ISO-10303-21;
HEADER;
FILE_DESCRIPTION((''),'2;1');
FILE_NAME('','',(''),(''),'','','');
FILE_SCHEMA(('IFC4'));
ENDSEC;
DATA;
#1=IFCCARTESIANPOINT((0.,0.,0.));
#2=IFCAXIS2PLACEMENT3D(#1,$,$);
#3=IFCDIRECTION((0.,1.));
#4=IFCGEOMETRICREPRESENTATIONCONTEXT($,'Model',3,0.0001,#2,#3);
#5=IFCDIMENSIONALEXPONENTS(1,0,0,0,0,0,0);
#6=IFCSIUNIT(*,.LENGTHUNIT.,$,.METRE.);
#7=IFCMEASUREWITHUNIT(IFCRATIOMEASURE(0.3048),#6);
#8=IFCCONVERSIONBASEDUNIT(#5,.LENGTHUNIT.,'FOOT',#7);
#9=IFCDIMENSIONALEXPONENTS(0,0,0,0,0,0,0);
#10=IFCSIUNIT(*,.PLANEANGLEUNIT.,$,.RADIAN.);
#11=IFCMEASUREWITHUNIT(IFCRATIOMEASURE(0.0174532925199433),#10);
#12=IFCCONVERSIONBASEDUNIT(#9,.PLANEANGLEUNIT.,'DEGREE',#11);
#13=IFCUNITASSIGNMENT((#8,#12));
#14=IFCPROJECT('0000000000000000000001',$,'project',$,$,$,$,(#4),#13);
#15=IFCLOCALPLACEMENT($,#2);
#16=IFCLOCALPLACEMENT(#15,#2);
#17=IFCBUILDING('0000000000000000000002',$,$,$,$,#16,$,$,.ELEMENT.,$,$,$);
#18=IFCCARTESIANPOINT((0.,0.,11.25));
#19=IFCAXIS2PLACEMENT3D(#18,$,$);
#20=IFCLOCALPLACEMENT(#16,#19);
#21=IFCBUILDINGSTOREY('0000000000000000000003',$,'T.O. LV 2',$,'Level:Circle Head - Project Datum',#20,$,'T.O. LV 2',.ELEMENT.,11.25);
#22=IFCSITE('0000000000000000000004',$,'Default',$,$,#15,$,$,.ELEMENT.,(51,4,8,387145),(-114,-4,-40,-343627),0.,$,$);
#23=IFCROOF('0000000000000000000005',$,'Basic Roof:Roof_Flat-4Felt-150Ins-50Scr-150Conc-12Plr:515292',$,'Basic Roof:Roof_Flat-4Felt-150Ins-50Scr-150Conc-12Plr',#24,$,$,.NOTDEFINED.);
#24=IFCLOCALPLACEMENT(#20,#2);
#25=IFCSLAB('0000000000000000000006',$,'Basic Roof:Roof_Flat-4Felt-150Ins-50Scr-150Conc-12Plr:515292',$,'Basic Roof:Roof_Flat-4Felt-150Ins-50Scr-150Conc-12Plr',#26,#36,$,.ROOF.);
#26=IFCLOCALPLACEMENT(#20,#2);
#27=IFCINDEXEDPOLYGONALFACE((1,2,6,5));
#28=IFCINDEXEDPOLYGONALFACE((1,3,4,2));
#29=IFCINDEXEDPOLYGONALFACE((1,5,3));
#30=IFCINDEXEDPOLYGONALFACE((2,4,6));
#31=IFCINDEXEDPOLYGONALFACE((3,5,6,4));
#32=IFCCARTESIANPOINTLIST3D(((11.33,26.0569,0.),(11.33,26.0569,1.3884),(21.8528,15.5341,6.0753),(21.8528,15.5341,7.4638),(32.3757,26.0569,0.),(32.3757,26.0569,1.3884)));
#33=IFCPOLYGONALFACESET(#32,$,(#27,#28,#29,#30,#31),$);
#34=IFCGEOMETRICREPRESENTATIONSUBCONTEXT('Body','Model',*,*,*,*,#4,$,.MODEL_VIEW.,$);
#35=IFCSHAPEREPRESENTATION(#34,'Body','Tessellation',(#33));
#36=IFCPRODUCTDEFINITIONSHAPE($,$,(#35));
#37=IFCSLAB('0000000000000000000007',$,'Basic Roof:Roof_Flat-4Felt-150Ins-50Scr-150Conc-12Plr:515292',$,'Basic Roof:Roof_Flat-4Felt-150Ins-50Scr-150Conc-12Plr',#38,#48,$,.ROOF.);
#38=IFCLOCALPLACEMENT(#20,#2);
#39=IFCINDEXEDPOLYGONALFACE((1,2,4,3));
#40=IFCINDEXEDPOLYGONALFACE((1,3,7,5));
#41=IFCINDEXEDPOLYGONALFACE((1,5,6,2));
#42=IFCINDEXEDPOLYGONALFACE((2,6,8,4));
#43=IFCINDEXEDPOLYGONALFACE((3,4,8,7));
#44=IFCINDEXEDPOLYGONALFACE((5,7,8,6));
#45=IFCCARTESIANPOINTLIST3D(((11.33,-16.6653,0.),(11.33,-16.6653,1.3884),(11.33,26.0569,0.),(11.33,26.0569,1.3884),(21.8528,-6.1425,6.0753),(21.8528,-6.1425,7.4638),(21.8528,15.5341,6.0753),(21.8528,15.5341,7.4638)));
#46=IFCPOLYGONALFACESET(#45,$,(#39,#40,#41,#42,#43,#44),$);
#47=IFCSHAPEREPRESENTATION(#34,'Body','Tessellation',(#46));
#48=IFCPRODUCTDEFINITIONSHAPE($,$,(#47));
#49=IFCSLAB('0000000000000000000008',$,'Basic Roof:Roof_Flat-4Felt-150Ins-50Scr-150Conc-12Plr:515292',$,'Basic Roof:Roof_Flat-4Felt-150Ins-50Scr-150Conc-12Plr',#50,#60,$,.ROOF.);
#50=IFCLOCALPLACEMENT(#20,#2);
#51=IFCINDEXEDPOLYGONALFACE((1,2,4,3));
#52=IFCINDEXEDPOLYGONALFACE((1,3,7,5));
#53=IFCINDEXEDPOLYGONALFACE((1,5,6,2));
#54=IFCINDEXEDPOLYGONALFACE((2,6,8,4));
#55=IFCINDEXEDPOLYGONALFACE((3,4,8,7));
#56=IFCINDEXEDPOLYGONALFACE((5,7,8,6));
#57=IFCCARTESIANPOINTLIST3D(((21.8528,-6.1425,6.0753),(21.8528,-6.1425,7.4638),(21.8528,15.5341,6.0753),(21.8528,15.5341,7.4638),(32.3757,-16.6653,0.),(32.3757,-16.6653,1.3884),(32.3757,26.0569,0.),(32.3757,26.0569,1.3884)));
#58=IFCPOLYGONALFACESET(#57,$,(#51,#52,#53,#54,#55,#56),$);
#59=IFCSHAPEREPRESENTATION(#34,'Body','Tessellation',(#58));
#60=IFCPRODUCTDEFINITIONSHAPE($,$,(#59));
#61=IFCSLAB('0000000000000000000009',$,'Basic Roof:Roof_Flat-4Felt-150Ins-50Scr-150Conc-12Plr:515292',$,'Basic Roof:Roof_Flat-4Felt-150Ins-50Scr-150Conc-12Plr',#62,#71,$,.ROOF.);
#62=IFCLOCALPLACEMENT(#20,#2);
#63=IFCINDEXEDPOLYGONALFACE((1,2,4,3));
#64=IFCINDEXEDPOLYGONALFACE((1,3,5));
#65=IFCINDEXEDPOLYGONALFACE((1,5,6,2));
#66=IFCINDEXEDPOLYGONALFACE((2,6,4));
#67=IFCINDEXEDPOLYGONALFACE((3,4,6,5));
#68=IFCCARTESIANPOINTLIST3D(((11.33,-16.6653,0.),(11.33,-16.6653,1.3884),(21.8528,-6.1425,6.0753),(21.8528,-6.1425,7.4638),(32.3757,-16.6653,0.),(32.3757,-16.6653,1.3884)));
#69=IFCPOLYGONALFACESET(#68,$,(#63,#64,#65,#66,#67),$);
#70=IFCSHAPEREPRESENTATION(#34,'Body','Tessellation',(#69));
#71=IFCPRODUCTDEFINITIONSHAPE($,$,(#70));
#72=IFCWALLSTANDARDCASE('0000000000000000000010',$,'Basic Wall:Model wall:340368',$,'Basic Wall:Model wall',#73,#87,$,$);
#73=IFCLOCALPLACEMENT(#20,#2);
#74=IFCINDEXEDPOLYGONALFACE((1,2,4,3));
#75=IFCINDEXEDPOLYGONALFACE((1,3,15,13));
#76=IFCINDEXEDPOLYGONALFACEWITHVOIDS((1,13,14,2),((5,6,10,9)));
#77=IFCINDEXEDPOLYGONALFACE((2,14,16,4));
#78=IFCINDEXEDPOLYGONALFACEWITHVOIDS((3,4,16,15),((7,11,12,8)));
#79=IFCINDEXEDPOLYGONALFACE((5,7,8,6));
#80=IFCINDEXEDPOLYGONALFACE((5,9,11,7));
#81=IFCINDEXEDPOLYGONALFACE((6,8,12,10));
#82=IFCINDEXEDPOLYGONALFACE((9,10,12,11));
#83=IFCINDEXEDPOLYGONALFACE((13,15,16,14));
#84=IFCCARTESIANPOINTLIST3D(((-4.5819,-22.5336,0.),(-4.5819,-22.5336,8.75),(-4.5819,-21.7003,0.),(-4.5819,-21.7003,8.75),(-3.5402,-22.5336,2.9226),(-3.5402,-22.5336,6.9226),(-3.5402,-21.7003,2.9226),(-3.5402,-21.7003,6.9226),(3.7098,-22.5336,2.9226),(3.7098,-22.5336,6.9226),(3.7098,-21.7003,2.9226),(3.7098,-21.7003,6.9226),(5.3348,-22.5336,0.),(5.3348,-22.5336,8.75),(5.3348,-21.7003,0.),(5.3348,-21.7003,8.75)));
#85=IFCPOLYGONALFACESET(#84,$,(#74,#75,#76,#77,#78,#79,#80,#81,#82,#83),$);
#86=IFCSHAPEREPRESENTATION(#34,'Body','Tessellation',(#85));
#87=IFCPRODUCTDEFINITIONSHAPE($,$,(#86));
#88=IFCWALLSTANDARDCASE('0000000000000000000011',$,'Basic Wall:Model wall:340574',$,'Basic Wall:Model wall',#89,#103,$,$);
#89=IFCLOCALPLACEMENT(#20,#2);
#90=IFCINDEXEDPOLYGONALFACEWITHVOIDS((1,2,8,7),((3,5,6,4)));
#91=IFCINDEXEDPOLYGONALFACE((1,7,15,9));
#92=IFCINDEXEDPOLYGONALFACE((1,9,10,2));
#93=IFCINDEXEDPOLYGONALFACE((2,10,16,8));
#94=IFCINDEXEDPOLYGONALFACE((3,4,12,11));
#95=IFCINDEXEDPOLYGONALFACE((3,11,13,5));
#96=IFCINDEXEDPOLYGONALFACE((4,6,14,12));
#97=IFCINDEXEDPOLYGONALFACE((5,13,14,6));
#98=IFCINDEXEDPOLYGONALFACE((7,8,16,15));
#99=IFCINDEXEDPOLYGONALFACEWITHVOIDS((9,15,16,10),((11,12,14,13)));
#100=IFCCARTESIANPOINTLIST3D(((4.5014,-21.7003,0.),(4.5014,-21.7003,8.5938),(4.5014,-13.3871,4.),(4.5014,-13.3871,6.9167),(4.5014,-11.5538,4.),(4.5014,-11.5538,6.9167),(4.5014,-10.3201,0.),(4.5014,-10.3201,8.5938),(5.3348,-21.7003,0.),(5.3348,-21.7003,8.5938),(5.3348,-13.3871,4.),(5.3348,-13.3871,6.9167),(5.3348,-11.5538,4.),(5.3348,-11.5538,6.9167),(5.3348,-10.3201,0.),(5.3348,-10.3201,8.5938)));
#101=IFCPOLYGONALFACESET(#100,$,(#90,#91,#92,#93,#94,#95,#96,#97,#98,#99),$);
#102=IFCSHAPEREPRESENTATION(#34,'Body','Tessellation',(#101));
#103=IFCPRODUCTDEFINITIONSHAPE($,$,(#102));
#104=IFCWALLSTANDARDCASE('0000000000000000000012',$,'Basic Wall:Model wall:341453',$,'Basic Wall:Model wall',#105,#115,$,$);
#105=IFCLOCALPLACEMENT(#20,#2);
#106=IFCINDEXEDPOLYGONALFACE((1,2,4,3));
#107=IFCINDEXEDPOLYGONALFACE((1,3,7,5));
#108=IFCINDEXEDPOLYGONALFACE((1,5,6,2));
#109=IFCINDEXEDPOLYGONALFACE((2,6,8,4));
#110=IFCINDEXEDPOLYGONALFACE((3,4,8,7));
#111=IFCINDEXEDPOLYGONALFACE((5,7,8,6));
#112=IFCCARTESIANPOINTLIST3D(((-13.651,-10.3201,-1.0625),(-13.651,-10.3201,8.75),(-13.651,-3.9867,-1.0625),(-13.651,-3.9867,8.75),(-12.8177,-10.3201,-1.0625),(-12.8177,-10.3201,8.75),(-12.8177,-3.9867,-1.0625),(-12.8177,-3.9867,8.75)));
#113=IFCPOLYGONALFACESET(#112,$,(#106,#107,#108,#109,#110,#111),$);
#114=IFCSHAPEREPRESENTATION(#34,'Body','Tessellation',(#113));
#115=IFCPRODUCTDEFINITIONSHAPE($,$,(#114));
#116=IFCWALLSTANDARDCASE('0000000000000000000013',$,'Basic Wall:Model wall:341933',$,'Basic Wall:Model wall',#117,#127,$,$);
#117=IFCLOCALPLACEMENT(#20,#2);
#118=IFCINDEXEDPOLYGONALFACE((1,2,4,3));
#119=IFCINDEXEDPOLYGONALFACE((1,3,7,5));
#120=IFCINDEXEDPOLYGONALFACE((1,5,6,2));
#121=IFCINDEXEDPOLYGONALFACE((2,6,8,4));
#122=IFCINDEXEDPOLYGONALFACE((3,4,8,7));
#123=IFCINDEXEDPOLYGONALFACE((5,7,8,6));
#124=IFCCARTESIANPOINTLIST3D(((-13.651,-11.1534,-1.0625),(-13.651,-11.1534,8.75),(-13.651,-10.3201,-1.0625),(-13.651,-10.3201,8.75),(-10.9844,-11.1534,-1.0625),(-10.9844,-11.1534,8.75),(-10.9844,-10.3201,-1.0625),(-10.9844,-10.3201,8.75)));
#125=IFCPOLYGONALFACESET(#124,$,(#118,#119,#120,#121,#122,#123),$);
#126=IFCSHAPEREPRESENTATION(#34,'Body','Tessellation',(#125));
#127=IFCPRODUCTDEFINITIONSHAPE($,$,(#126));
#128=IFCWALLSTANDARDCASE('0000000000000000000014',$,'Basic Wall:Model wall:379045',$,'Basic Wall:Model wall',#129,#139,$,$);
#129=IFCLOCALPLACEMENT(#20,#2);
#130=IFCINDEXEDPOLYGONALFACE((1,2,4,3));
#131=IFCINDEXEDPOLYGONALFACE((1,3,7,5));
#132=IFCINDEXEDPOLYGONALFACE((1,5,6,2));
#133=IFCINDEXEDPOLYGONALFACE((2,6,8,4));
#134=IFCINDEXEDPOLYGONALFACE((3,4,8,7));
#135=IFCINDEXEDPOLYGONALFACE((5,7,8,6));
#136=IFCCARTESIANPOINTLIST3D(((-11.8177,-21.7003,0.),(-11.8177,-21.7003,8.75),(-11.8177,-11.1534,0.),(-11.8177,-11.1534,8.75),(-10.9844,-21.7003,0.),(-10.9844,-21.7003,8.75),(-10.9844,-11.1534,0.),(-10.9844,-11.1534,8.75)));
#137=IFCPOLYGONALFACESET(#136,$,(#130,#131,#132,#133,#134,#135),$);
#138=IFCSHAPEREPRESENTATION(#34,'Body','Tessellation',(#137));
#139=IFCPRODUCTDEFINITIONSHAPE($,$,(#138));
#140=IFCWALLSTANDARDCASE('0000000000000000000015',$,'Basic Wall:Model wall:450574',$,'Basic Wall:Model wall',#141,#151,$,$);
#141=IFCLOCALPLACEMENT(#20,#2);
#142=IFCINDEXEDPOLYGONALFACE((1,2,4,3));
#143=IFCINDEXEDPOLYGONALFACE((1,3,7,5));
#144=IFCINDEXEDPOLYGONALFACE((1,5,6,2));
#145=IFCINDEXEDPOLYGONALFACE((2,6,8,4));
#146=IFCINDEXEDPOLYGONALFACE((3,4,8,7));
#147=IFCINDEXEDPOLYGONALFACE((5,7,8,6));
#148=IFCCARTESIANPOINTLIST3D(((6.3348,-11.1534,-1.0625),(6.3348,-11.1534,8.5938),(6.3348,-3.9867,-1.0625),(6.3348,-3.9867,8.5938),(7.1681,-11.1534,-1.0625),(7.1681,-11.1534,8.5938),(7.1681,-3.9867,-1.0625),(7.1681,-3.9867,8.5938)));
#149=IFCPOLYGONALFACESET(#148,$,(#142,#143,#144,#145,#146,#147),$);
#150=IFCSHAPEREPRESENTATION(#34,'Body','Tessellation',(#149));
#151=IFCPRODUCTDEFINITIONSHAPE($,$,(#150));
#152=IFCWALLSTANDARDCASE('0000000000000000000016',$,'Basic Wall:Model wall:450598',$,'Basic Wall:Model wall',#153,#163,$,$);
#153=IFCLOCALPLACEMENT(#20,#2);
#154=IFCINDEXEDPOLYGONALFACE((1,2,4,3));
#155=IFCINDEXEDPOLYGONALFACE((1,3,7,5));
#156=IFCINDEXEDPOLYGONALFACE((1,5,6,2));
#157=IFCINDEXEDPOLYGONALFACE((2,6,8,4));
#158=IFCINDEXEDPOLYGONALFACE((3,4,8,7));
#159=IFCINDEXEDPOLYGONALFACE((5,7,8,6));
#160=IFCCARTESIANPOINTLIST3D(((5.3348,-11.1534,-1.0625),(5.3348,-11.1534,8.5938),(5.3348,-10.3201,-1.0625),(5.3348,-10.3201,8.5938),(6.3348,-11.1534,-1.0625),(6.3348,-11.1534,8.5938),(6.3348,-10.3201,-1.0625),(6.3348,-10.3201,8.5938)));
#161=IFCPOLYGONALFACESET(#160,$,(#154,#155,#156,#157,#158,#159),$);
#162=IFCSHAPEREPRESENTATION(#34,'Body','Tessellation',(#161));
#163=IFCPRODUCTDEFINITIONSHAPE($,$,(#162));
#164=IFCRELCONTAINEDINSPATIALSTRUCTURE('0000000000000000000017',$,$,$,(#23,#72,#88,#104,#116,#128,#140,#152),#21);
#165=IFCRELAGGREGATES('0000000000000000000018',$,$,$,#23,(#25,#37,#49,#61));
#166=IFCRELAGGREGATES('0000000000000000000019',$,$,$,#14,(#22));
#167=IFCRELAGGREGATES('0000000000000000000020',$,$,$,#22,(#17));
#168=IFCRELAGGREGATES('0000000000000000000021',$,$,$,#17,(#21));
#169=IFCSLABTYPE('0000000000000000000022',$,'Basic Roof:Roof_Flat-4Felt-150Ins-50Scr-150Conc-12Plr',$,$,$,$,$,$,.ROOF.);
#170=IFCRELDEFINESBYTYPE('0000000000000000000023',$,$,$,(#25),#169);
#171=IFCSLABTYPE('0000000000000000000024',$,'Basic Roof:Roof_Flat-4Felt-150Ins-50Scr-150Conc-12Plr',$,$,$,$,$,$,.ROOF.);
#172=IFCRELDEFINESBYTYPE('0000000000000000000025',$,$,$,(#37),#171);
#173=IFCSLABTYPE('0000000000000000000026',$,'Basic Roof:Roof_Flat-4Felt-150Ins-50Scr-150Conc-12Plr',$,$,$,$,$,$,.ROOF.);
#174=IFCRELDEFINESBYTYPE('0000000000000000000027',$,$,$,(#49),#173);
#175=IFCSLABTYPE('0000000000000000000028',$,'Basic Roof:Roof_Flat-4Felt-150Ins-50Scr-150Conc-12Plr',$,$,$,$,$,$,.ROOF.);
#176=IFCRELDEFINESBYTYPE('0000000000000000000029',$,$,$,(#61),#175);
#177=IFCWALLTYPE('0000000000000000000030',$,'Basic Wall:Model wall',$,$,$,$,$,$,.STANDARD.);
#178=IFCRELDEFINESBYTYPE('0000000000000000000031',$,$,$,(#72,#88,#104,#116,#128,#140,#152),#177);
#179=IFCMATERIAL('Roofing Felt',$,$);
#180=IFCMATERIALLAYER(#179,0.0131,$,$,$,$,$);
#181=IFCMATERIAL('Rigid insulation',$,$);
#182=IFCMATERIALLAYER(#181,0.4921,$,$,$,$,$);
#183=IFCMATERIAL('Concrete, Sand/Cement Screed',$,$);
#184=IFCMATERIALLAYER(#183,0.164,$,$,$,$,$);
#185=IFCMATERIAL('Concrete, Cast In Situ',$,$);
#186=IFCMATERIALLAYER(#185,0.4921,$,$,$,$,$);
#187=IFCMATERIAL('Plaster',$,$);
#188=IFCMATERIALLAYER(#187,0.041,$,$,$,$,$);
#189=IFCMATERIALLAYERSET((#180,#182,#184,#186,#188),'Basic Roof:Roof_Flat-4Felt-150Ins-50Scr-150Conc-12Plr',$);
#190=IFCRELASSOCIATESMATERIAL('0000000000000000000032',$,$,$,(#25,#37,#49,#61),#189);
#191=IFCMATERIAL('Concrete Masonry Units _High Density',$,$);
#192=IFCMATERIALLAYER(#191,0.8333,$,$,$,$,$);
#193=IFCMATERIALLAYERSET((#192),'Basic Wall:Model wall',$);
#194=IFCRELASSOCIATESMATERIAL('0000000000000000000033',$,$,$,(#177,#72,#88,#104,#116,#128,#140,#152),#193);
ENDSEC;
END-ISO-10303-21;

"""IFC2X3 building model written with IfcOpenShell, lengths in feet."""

from ifc_helpers import new_model, entity, si_unit, converted_unit, direction, frame, frame_2d, origin, place, context, subcontext, project, spatial, polyline, rectangle, outline, extrude, material, layer, layer_set, layer_usage, type_object, element, aggregate, save


model = new_model("IFC2X3")

# Units and contexts
model_context = context("Model", 3, precision=0.0001, world=origin(), true_north=direction((0.0, 1.0)))
body_context = subcontext(model_context, "Body", "Model", "MODEL_VIEW")
ifc_project = project(units=[converted_unit("LENGTHUNIT", "FOOT", entity("IfcRatioMeasure", 0.3048), si_unit("LENGTHUNIT", "METRE"), dimensions=[1, 0, 0, 0, 0, 0, 0]), converted_unit("PLANEANGLEUNIT", "DEGREE", entity("IfcRatioMeasure", 0.0174532925199433), si_unit("PLANEANGLEUNIT", "RADIAN"), dimensions=[0, 0, 0, 0, 0, 0, 0])], contexts=[model_context])

# Site, building, storey
site_placement = place(None, origin())
site = spatial("IfcSite", under=ifc_project, at=site_placement, Name="Default", CompositionType="ELEMENT", RefLatitude=(51, 4, 8, 387145), RefLongitude=(-114, -4, -40, -343627), RefElevation=0.0)
building_placement = place(site_placement, origin())
building = spatial("IfcBuilding", under=site, at=building_placement, CompositionType="ELEMENT")
storey_placement = place(building_placement, frame((0.0, 0.0, 11.25)))
storey = spatial("IfcBuildingStorey", under=building, at=storey_placement, Name="T.O. LV 2", ObjectType="Level:Circle Head - Project Datum", LongName="T.O. LV 2", CompositionType="ELEMENT", Elevation=11.25)

# Roof, slabs
roof_placement = place(storey_placement, frame((11.33, -16.6653, 0.0)))
roof = element("IfcRoof", 1, at=roof_placement, inside=storey, Name="Basic Roof:Roof_Flat-4Felt-150Ins-50Scr-150Conc-12Plr:515292", ObjectType="Basic Roof:Roof_Flat-4Felt-150Ins-50Scr-150Conc-12Plr", ShapeType="NOTDEFINED")
ifc_material_1 = material(Name="Roofing Felt")
ifc_layer_1 = layer(ifc_material_1, 0.0131)
ifc_material_2 = material(Name="Rigid insulation")
ifc_layer_2 = layer(ifc_material_2, 0.4921)
ifc_material_3 = material(Name="Concrete, Sand/Cement Screed")
ifc_layer_3 = layer(ifc_material_3, 0.164)
ifc_material_4 = material(Name="Concrete, Cast In Situ")
ifc_layer_4 = layer(ifc_material_4, 0.4921)
ifc_material_5 = material(Name="Plaster")
ifc_layer_5 = layer(ifc_material_5, 0.041)
ifc_layer_set_1 = layer_set([ifc_layer_1, ifc_layer_2, ifc_layer_3, ifc_layer_4, ifc_layer_5], Name="Basic Roof:Roof_Flat-4Felt-150Ins-50Scr-150Conc-12Plr")
slab_type_1 = type_object("IfcSlabType", Name="Basic Roof:Roof_Flat-4Felt-150Ins-50Scr-150Conc-12Plr", PredefinedType="ROOF")
slab_1_placement = place(roof_placement, origin())
slab_1 = element("IfcSlab", 2, at=slab_1_placement, type_object=slab_type_1, material=ifc_layer_set_1, Name="Basic Roof:Roof_Flat-4Felt-150Ins-50Scr-150Conc-12Plr:515292", ObjectType="Basic Roof:Roof_Flat-4Felt-150Ins-50Scr-150Conc-12Plr", PredefinedType="ROOF", context=body_context, shape_type="SweptSolid", body=[
    extrude(outline(polyline([(10.5228, 6.0753), (-10.5228, 6.0753), (0.0, -6.0753), (10.5228, 6.0753)])), frame((10.5228, 37.4608, 3.0377), z_axis=(0.0, 0.5, 0.866025), x_axis=(1.0, 0.0, 0.0)), (0.0, -0.5, 0.866025), 1.3884),
])
slab_type_2 = type_object("IfcSlabType", Name="Basic Roof:Roof_Flat-4Felt-150Ins-50Scr-150Conc-12Plr", PredefinedType="ROOF")
slab_2_placement = place(roof_placement, origin())
slab_2 = element("IfcSlab", 3, at=slab_2_placement, type_object=slab_type_2, material=ifc_layer_set_1, Name="Basic Roof:Roof_Flat-4Felt-150Ins-50Scr-150Conc-12Plr:515292", ObjectType="Basic Roof:Roof_Flat-4Felt-150Ins-50Scr-150Conc-12Plr", PredefinedType="ROOF", context=body_context, shape_type="SweptSolid", body=[
    extrude(outline(polyline([(-6.0753, 21.3611), (-6.0753, -21.3611), (6.0753, -10.8383), (6.0753, 10.8383), (-6.0753, 21.3611)])), frame((5.2614, 21.3611, 3.0377), z_axis=(-0.5, 0.0, 0.866025), x_axis=(0.866025, 0.0, 0.5)), (0.5, 0.0, 0.866025), 1.3884),
])
slab_type_3 = type_object("IfcSlabType", Name="Basic Roof:Roof_Flat-4Felt-150Ins-50Scr-150Conc-12Plr", PredefinedType="ROOF")
slab_3_placement = place(roof_placement, origin())
slab_3 = element("IfcSlab", 4, at=slab_3_placement, type_object=slab_type_3, material=ifc_layer_set_1, Name="Basic Roof:Roof_Flat-4Felt-150Ins-50Scr-150Conc-12Plr:515292", ObjectType="Basic Roof:Roof_Flat-4Felt-150Ins-50Scr-150Conc-12Plr", PredefinedType="ROOF", context=body_context, shape_type="SweptSolid", body=[
    extrude(outline(polyline([(-6.0753, 10.8383), (-6.0753, -10.8383), (6.0753, -21.3611), (6.0753, 21.3611), (-6.0753, 10.8383)])), frame((15.7842, 21.3611, 3.0377), z_axis=(0.5, 0.0, 0.866025), x_axis=(0.866025, 0.0, -0.5)), (-0.5, 0.0, 0.866025), 1.3884),
])
slab_type_4 = type_object("IfcSlabType", Name="Basic Roof:Roof_Flat-4Felt-150Ins-50Scr-150Conc-12Plr", PredefinedType="ROOF")
slab_4_placement = place(roof_placement, origin())
slab_4 = element("IfcSlab", 5, at=slab_4_placement, type_object=slab_type_4, material=ifc_layer_set_1, Name="Basic Roof:Roof_Flat-4Felt-150Ins-50Scr-150Conc-12Plr:515292", ObjectType="Basic Roof:Roof_Flat-4Felt-150Ins-50Scr-150Conc-12Plr", PredefinedType="ROOF", context=body_context, shape_type="SweptSolid", body=[
    extrude(outline(polyline([(-10.5228, -6.0753), (10.5228, -6.0753), (0.0, 6.0753), (-10.5228, -6.0753)])), frame((10.5228, 5.2614, 3.0377), z_axis=(0.0, -0.5, 0.866025), x_axis=(1.0, 0.0, 0.0)), (0.0, 0.5, 0.866025), 1.3884),
])
aggregate(roof, [slab_1, slab_2, slab_3, slab_4])

# Walls, openings
ifc_material_6 = material(Name="Concrete Masonry Units _High Density")
ifc_layer_6 = layer(ifc_material_6, 0.8333)
ifc_layer_set_2 = layer_set([ifc_layer_6], Name="Basic Wall:Model wall")
ifc_layer_usage_1 = layer_usage(ifc_layer_set_2, "AXIS2", "NEGATIVE", 0.4167)
wall_type_1 = type_object("IfcWallType", Name="Basic Wall:Model wall", PredefinedType="STANDARD", material=ifc_layer_set_2)
wall_1_placement = place(storey_placement, frame((5.3348, -22.117, 0.0), z_axis=(0.0, 0.0, 1.0), x_axis=(-1.0, 0.0, 0.0)))
wall_1 = element("IfcWallStandardCase", 6, at=wall_1_placement, inside=storey, type_object=wall_type_1, material=ifc_layer_usage_1, Name="Basic Wall:Model wall:340368", ObjectType="Basic Wall:Model wall", context=body_context, shape_type="SweptSolid", body=[
    extrude(rectangle(XDim=9.9167, YDim=0.8333, at=frame_2d((4.9583, 0.0), x_axis=(-1.0, 0.0))), origin(), (0.0, 0.0, 1.0), 8.75),
])
opening_1_placement = place(wall_1_placement, frame((1.625, -0.4167, 2.9226)))
element("IfcOpeningElement", 7, at=opening_1_placement, cuts=wall_1, ObjectType="Opening", context=body_context, shape_type="SweptSolid", body=[
    extrude(rectangle(XDim=4.0, YDim=7.25, at=frame_2d((2.0, 3.625), x_axis=(-1.0, 0.0))), frame((0.0, 0.0, 0.0), z_axis=(0.0, 1.0, 0.0), x_axis=(0.0, 0.0, 1.0)), (0.0, 0.0, 1.0), 0.8333),
])
ifc_layer_usage_2 = layer_usage(ifc_layer_set_2, "AXIS2", "NEGATIVE", 0.4167)
wall_2_placement = place(storey_placement, frame((4.9181, -21.7003, 0.0), z_axis=(0.0, 0.0, 1.0), x_axis=(0.0, 1.0, 0.0)))
wall_2 = element("IfcWallStandardCase", 8, at=wall_2_placement, inside=storey, type_object=wall_type_1, material=ifc_layer_usage_2, Name="Basic Wall:Model wall:340574", ObjectType="Basic Wall:Model wall", context=body_context, shape_type="SweptSolid", body=[
    extrude(rectangle(XDim=11.3802, YDim=0.8333, at=frame_2d((5.6901, 0.0), x_axis=(-1.0, 0.0))), origin(), (0.0, 0.0, 1.0), 8.5938),
])
opening_2_placement = place(wall_2_placement, frame((10.1465, 0.4167, 4.0)))
element("IfcOpeningElement", 9, at=opening_2_placement, cuts=wall_2, ObjectType="Opening", context=body_context, shape_type="SweptSolid", body=[
    extrude(rectangle(XDim=2.9167, YDim=1.8333, at=frame_2d((1.4583, 0.9167), x_axis=(-1.0, 0.0))), frame((0.0, 0.0, 0.0), z_axis=(0.0, -1.0, 0.0), x_axis=(0.0, 0.0, 1.0)), (0.0, 0.0, 1.0), 0.8333),
])

# Walls
ifc_layer_usage_3 = layer_usage(ifc_layer_set_2, "AXIS2", "NEGATIVE", 0.4167)
wall_3_placement = place(storey_placement, frame((-13.2344, -3.9867, -1.0625), z_axis=(0.0, 0.0, 1.0), x_axis=(0.0, -1.0, 0.0)))
element("IfcWallStandardCase", 10, at=wall_3_placement, inside=storey, type_object=wall_type_1, material=ifc_layer_usage_3, Name="Basic Wall:Model wall:341453", ObjectType="Basic Wall:Model wall", context=body_context, shape_type="SweptSolid", body=[
    extrude(rectangle(XDim=6.3333, YDim=0.8333, at=frame_2d((3.1667, 0.0), x_axis=(-1.0, 0.0))), origin(), (0.0, 0.0, 1.0), 9.8125),
])
ifc_layer_usage_4 = layer_usage(ifc_layer_set_2, "AXIS2", "NEGATIVE", 0.4167)
wall_4_placement = place(storey_placement, frame((-13.651, -10.7367, -1.0625)))
element("IfcWallStandardCase", 11, at=wall_4_placement, inside=storey, type_object=wall_type_1, material=ifc_layer_usage_4, Name="Basic Wall:Model wall:341933", ObjectType="Basic Wall:Model wall", context=body_context, shape_type="SweptSolid", body=[
    extrude(rectangle(XDim=2.6667, YDim=0.8333, at=frame_2d((1.3333, 0.0), x_axis=(-1.0, 0.0))), origin(), (0.0, 0.0, 1.0), 9.8125),
])
ifc_layer_usage_5 = layer_usage(ifc_layer_set_2, "AXIS2", "NEGATIVE", 0.4167)
wall_5_placement = place(storey_placement, frame((-11.401, -11.1534, 0.0), z_axis=(0.0, 0.0, 1.0), x_axis=(0.0, -1.0, 0.0)))
element("IfcWallStandardCase", 12, at=wall_5_placement, inside=storey, type_object=wall_type_1, material=ifc_layer_usage_5, Name="Basic Wall:Model wall:379045", ObjectType="Basic Wall:Model wall", context=body_context, shape_type="SweptSolid", body=[
    extrude(rectangle(XDim=10.5469, YDim=0.8333, at=frame_2d((5.2734, 0.0), x_axis=(-1.0, 0.0))), origin(), (0.0, 0.0, 1.0), 8.75),
])
ifc_layer_usage_6 = layer_usage(ifc_layer_set_2, "AXIS2", "NEGATIVE", 0.4167)
wall_6_placement = place(storey_placement, frame((6.7514, -3.9867, -1.0625), z_axis=(0.0, 0.0, 1.0), x_axis=(0.0, -1.0, 0.0)))
element("IfcWallStandardCase", 13, at=wall_6_placement, inside=storey, type_object=wall_type_1, material=ifc_layer_usage_6, Name="Basic Wall:Model wall:450574", ObjectType="Basic Wall:Model wall", context=body_context, shape_type="SweptSolid", body=[
    extrude(rectangle(XDim=7.1667, YDim=0.8333, at=frame_2d((3.5833, 0.0), x_axis=(-1.0, 0.0))), origin(), (0.0, 0.0, 1.0), 9.6563),
])
ifc_layer_usage_7 = layer_usage(ifc_layer_set_2, "AXIS2", "NEGATIVE", 0.4167)
wall_7_placement = place(storey_placement, frame((6.3348, -10.7367, -1.0625), z_axis=(0.0, 0.0, 1.0), x_axis=(-1.0, 0.0, 0.0)))
element("IfcWallStandardCase", 14, at=wall_7_placement, inside=storey, type_object=wall_type_1, material=ifc_layer_usage_7, Name="Basic Wall:Model wall:450598", ObjectType="Basic Wall:Model wall", context=body_context, shape_type="SweptSolid", body=[
    extrude(rectangle(XDim=1.0, YDim=0.8333, at=frame_2d((0.5, 0.0), x_axis=(-1.0, 0.0))), origin(), (0.0, 0.0, 1.0), 9.6563),
])

save(model, "model.ifc")
